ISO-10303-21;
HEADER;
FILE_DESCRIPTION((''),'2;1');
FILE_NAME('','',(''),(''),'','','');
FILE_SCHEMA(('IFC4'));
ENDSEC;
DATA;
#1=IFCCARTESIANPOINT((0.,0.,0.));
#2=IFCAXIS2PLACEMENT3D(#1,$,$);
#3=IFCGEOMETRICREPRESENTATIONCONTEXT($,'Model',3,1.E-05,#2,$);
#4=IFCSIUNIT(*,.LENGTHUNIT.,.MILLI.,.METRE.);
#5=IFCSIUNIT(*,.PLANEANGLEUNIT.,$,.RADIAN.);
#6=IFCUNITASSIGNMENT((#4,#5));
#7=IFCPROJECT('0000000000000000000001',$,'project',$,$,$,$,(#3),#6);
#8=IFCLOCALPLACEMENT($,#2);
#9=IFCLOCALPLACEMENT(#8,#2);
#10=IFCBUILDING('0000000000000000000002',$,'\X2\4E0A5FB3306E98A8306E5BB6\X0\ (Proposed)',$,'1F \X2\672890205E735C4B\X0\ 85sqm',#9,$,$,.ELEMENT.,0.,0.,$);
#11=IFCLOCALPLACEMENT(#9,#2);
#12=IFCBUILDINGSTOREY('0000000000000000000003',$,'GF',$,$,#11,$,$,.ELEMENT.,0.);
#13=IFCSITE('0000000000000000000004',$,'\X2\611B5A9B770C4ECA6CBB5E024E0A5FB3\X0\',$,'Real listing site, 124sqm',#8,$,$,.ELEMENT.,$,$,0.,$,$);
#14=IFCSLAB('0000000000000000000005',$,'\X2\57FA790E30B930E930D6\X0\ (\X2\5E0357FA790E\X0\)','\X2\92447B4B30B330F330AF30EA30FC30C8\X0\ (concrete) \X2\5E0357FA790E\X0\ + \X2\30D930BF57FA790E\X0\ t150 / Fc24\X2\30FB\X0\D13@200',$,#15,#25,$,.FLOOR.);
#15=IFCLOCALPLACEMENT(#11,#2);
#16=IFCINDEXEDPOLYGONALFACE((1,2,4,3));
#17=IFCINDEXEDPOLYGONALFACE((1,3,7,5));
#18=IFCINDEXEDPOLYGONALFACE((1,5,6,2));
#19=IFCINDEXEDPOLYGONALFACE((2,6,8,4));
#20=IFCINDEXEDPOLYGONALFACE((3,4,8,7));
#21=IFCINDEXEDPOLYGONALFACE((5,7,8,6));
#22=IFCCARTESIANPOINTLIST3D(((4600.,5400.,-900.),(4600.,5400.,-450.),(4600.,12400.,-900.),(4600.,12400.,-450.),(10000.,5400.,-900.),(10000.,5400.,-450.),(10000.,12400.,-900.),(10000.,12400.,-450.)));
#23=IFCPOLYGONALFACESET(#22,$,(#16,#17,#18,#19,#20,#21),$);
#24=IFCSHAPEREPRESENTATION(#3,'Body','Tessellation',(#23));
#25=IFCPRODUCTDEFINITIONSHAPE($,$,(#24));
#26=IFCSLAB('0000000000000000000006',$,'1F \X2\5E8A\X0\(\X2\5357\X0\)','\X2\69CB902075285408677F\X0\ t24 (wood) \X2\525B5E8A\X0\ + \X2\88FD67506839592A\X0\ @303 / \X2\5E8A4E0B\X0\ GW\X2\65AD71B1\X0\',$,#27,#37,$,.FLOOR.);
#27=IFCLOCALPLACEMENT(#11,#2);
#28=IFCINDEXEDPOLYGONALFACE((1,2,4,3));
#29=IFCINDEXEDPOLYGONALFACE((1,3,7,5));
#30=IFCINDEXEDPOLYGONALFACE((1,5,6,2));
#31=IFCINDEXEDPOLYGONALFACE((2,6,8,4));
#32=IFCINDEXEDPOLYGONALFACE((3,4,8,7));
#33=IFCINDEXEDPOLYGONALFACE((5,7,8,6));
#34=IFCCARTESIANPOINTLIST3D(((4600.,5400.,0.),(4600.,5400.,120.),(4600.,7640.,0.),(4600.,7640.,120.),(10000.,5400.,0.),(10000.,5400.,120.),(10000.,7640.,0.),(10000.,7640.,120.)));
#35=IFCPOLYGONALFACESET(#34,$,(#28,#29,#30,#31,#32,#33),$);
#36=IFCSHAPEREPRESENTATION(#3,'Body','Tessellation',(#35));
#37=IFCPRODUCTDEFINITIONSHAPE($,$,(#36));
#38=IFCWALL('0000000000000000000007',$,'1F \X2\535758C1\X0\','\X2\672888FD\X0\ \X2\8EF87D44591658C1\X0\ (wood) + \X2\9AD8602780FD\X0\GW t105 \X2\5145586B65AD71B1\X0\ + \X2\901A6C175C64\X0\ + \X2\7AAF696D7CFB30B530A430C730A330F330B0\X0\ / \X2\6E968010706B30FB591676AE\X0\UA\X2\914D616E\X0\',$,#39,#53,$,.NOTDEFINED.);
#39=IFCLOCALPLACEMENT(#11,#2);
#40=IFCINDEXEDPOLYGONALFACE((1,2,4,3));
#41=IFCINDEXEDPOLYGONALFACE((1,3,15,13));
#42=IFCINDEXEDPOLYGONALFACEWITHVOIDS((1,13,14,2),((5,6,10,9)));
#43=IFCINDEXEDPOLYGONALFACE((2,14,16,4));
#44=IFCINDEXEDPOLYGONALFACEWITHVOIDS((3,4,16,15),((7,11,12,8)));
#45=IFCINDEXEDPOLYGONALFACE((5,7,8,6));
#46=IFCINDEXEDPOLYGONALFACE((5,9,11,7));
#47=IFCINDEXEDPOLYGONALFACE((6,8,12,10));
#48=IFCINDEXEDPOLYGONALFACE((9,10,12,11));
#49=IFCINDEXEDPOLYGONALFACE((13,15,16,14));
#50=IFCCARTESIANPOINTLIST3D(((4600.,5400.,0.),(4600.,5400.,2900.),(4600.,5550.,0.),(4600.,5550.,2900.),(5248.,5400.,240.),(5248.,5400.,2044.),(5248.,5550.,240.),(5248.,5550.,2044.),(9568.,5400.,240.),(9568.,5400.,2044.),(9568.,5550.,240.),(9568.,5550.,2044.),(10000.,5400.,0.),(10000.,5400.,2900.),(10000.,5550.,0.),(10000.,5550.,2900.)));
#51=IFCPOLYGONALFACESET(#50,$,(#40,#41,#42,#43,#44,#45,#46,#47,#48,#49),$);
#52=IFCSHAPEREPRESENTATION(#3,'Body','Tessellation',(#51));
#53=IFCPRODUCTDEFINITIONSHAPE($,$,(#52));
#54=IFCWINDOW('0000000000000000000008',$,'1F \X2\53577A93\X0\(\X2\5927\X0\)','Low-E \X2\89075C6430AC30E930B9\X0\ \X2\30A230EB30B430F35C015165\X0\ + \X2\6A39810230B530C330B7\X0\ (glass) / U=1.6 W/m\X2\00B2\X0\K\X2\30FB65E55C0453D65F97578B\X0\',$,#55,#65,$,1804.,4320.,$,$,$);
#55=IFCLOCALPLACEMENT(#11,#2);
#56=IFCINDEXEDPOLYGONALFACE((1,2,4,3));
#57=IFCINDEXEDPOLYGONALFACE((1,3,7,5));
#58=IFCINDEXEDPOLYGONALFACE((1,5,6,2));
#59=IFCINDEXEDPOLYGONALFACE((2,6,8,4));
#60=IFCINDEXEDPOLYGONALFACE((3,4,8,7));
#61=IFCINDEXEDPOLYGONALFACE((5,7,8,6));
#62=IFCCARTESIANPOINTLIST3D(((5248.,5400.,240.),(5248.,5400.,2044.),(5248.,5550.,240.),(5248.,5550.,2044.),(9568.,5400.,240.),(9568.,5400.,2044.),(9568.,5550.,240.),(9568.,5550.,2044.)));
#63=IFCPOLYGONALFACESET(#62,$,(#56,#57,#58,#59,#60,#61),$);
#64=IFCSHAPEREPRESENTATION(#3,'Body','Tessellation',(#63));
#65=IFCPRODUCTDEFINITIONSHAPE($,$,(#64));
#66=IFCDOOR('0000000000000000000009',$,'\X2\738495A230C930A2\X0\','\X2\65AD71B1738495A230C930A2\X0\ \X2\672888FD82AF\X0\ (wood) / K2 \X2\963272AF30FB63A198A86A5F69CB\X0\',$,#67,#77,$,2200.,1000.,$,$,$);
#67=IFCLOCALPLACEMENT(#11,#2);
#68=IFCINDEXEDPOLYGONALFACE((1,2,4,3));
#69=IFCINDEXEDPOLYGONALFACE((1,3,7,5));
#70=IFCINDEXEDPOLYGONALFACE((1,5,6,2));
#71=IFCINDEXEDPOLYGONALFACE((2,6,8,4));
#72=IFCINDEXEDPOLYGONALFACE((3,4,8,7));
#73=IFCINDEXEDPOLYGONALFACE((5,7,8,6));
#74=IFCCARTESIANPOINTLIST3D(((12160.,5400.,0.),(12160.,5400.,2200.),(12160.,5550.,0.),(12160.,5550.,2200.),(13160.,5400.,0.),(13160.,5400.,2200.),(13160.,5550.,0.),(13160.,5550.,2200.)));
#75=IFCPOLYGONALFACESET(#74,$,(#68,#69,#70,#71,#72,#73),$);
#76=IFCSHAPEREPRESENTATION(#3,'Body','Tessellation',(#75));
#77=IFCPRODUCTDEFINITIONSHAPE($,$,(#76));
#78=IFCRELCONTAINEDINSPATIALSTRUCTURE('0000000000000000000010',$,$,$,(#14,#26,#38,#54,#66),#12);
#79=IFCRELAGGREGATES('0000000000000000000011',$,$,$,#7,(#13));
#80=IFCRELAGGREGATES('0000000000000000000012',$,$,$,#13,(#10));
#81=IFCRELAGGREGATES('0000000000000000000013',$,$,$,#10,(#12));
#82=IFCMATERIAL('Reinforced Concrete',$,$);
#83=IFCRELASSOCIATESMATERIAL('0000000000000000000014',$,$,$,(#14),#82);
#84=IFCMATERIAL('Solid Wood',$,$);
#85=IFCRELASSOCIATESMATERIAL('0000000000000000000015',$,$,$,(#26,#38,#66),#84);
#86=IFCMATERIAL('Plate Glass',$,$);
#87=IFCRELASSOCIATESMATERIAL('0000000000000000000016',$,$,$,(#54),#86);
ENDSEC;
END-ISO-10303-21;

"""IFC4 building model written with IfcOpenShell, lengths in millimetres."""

from ifc_helpers import new_model, si_unit, frame, frame_2d, origin, place, context, project, spatial, rectangle, extrude, material, element, fill, save


model = new_model("IFC4")

# Units and contexts
model_context = context("Model", 3, precision=1e-05, world=origin())
ifc_project = project(units=[si_unit("LENGTHUNIT", "METRE", prefix="MILLI"), si_unit("PLANEANGLEUNIT", "RADIAN")], contexts=[model_context])

# Site, building, storey
site_placement = place(None, origin())
site = spatial("IfcSite", under=ifc_project, at=site_placement, Name="愛媛県今治市上徳", ObjectType="Real listing site, 124sqm", CompositionType="ELEMENT", RefElevation=0.0)
building_placement = place(site_placement, origin())
building = spatial("IfcBuilding", under=site, at=building_placement, Name="上徳の風の家 (Proposed)", ObjectType="1F 木造平屋 85sqm", CompositionType="ELEMENT", ElevationOfRefHeight=0.0, ElevationOfTerrain=0.0)
storey_placement = place(building_placement, origin())
storey = spatial("IfcBuildingStorey", under=building, at=storey_placement, Name="GF", CompositionType="ELEMENT", Elevation=0.0)

# Slabs
ifc_material_1 = material(Name="Reinforced Concrete")
slab_1_placement = place(storey_placement, frame((2300.0, 2700.0, -450.0)))
element("IfcSlab", 1, at=slab_1_placement, inside=storey, material=ifc_material_1, Name="基礎スラブ (布基礎)", Description="鉄筋コンクリート (concrete) 布基礎 + ベタ基礎 t150 / Fc24・D13@200", PredefinedType="FLOOR", context=model_context, shape_type="SweptSolid", body=[
    extrude(rectangle(XDim=5400.0, YDim=7000.0, at=frame_2d((2700.0, 3500.0))), frame((2300.0, 2700.0, -450.0)), (0.0, 0.0, 1.0), 450.0),
])
ifc_material_2 = material(Name="Solid Wood")
slab_2_placement = place(storey_placement, frame((2300.0, 2700.0, 0.0)))
element("IfcSlab", 2, at=slab_2_placement, inside=storey, material=ifc_material_2, Name="1F 床(南)", Description="構造用合板 t24 (wood) 剛床 + 製材根太 @303 / 床下 GW断熱", PredefinedType="FLOOR", context=model_context, shape_type="SweptSolid", body=[
    extrude(rectangle(XDim=5400.0, YDim=2240.0, at=frame_2d((2700.0, 1120.0))), frame((2300.0, 2700.0, 0.0)), (0.0, 0.0, 1.0), 120.0),
])

# Wall, openings, window, door
wall_1_placement = place(storey_placement, frame((2300.0, 2700.0, 0.0)))
wall_1 = element("IfcWall", 3, at=wall_1_placement, inside=storey, material=ifc_material_2, Name="1F 南壁", Description="木製 軸組外壁 (wood) + 高性能GW t105 充填断熱 + 通気層 + 窯業系サイディング / 準耐火・外皮UA配慮", PredefinedType="NOTDEFINED", context=model_context, shape_type="SweptSolid", body=[
    extrude(rectangle(XDim=5400.0, YDim=150.0, at=frame_2d((2700.0, 75.0))), frame((2300.0, 2700.0, 0.0)), (0.0, 0.0, 1.0), 2900.0),
])
opening_1_placement = place(storey_placement, frame((2624.0, 2700.0, 120.0)))
opening_1 = element("IfcOpeningElement", 4, at=opening_1_placement, cuts=wall_1, PredefinedType="NOTDEFINED", context=model_context, shape_type="SweptSolid", body=[
    extrude(rectangle(XDim=4320.0, YDim=150.0, at=frame_2d((2160.0, 75.0))), frame((2624.0, 2700.0, 120.0)), (0.0, 0.0, 1.0), 1804.0),
])
opening_2_placement = place(storey_placement, frame((6080.0, 2700.0, 0.0)))
opening_2 = element("IfcOpeningElement", 5, at=opening_2_placement, cuts=wall_1, PredefinedType="NOTDEFINED", context=model_context, shape_type="SweptSolid", body=[
    extrude(rectangle(XDim=1000.0, YDim=150.0, at=frame_2d((500.0, 75.0))), frame((6080.0, 2700.0, 0.0)), (0.0, 0.0, 1.0), 2200.0),
])
ifc_material_3 = material(Name="Plate Glass")
window_1_placement = place(storey_placement, frame((2624.0, 2700.0, 120.0)))
window_1 = element("IfcWindow", 6, at=window_1_placement, inside=storey, material=ifc_material_3, Name="1F 南窓(大)", Description="Low-E 複層ガラス アルゴン封入 + 樹脂サッシ (glass) / U=1.6 W/m²K・日射取得型", OverallHeight=1804.0, OverallWidth=4320.0, context=model_context, shape_type="SweptSolid", body=[
    extrude(rectangle(XDim=4320.0, YDim=150.0, at=frame_2d((2160.0, 75.0))), frame((2624.0, 2700.0, 120.0)), (0.0, 0.0, 1.0), 1804.0),
])
fill(opening_1, window_1)
door_placement = place(storey_placement, frame((6080.0, 2700.0, 0.0)))
door = element("IfcDoor", 7, at=door_placement, inside=storey, material=ifc_material_2, Name="玄関ドア", Description="断熱玄関ドア 木製芯 (wood) / K2 防犯・採風機構", OverallHeight=2200.0, OverallWidth=1000.0, context=model_context, shape_type="SweptSolid", body=[
    extrude(rectangle(XDim=1000.0, YDim=150.0, at=frame_2d((500.0, 75.0))), frame((6080.0, 2700.0, 0.0)), (0.0, 0.0, 1.0), 2200.0),
])
fill(opening_2, door)

save(model, "model.ifc")
